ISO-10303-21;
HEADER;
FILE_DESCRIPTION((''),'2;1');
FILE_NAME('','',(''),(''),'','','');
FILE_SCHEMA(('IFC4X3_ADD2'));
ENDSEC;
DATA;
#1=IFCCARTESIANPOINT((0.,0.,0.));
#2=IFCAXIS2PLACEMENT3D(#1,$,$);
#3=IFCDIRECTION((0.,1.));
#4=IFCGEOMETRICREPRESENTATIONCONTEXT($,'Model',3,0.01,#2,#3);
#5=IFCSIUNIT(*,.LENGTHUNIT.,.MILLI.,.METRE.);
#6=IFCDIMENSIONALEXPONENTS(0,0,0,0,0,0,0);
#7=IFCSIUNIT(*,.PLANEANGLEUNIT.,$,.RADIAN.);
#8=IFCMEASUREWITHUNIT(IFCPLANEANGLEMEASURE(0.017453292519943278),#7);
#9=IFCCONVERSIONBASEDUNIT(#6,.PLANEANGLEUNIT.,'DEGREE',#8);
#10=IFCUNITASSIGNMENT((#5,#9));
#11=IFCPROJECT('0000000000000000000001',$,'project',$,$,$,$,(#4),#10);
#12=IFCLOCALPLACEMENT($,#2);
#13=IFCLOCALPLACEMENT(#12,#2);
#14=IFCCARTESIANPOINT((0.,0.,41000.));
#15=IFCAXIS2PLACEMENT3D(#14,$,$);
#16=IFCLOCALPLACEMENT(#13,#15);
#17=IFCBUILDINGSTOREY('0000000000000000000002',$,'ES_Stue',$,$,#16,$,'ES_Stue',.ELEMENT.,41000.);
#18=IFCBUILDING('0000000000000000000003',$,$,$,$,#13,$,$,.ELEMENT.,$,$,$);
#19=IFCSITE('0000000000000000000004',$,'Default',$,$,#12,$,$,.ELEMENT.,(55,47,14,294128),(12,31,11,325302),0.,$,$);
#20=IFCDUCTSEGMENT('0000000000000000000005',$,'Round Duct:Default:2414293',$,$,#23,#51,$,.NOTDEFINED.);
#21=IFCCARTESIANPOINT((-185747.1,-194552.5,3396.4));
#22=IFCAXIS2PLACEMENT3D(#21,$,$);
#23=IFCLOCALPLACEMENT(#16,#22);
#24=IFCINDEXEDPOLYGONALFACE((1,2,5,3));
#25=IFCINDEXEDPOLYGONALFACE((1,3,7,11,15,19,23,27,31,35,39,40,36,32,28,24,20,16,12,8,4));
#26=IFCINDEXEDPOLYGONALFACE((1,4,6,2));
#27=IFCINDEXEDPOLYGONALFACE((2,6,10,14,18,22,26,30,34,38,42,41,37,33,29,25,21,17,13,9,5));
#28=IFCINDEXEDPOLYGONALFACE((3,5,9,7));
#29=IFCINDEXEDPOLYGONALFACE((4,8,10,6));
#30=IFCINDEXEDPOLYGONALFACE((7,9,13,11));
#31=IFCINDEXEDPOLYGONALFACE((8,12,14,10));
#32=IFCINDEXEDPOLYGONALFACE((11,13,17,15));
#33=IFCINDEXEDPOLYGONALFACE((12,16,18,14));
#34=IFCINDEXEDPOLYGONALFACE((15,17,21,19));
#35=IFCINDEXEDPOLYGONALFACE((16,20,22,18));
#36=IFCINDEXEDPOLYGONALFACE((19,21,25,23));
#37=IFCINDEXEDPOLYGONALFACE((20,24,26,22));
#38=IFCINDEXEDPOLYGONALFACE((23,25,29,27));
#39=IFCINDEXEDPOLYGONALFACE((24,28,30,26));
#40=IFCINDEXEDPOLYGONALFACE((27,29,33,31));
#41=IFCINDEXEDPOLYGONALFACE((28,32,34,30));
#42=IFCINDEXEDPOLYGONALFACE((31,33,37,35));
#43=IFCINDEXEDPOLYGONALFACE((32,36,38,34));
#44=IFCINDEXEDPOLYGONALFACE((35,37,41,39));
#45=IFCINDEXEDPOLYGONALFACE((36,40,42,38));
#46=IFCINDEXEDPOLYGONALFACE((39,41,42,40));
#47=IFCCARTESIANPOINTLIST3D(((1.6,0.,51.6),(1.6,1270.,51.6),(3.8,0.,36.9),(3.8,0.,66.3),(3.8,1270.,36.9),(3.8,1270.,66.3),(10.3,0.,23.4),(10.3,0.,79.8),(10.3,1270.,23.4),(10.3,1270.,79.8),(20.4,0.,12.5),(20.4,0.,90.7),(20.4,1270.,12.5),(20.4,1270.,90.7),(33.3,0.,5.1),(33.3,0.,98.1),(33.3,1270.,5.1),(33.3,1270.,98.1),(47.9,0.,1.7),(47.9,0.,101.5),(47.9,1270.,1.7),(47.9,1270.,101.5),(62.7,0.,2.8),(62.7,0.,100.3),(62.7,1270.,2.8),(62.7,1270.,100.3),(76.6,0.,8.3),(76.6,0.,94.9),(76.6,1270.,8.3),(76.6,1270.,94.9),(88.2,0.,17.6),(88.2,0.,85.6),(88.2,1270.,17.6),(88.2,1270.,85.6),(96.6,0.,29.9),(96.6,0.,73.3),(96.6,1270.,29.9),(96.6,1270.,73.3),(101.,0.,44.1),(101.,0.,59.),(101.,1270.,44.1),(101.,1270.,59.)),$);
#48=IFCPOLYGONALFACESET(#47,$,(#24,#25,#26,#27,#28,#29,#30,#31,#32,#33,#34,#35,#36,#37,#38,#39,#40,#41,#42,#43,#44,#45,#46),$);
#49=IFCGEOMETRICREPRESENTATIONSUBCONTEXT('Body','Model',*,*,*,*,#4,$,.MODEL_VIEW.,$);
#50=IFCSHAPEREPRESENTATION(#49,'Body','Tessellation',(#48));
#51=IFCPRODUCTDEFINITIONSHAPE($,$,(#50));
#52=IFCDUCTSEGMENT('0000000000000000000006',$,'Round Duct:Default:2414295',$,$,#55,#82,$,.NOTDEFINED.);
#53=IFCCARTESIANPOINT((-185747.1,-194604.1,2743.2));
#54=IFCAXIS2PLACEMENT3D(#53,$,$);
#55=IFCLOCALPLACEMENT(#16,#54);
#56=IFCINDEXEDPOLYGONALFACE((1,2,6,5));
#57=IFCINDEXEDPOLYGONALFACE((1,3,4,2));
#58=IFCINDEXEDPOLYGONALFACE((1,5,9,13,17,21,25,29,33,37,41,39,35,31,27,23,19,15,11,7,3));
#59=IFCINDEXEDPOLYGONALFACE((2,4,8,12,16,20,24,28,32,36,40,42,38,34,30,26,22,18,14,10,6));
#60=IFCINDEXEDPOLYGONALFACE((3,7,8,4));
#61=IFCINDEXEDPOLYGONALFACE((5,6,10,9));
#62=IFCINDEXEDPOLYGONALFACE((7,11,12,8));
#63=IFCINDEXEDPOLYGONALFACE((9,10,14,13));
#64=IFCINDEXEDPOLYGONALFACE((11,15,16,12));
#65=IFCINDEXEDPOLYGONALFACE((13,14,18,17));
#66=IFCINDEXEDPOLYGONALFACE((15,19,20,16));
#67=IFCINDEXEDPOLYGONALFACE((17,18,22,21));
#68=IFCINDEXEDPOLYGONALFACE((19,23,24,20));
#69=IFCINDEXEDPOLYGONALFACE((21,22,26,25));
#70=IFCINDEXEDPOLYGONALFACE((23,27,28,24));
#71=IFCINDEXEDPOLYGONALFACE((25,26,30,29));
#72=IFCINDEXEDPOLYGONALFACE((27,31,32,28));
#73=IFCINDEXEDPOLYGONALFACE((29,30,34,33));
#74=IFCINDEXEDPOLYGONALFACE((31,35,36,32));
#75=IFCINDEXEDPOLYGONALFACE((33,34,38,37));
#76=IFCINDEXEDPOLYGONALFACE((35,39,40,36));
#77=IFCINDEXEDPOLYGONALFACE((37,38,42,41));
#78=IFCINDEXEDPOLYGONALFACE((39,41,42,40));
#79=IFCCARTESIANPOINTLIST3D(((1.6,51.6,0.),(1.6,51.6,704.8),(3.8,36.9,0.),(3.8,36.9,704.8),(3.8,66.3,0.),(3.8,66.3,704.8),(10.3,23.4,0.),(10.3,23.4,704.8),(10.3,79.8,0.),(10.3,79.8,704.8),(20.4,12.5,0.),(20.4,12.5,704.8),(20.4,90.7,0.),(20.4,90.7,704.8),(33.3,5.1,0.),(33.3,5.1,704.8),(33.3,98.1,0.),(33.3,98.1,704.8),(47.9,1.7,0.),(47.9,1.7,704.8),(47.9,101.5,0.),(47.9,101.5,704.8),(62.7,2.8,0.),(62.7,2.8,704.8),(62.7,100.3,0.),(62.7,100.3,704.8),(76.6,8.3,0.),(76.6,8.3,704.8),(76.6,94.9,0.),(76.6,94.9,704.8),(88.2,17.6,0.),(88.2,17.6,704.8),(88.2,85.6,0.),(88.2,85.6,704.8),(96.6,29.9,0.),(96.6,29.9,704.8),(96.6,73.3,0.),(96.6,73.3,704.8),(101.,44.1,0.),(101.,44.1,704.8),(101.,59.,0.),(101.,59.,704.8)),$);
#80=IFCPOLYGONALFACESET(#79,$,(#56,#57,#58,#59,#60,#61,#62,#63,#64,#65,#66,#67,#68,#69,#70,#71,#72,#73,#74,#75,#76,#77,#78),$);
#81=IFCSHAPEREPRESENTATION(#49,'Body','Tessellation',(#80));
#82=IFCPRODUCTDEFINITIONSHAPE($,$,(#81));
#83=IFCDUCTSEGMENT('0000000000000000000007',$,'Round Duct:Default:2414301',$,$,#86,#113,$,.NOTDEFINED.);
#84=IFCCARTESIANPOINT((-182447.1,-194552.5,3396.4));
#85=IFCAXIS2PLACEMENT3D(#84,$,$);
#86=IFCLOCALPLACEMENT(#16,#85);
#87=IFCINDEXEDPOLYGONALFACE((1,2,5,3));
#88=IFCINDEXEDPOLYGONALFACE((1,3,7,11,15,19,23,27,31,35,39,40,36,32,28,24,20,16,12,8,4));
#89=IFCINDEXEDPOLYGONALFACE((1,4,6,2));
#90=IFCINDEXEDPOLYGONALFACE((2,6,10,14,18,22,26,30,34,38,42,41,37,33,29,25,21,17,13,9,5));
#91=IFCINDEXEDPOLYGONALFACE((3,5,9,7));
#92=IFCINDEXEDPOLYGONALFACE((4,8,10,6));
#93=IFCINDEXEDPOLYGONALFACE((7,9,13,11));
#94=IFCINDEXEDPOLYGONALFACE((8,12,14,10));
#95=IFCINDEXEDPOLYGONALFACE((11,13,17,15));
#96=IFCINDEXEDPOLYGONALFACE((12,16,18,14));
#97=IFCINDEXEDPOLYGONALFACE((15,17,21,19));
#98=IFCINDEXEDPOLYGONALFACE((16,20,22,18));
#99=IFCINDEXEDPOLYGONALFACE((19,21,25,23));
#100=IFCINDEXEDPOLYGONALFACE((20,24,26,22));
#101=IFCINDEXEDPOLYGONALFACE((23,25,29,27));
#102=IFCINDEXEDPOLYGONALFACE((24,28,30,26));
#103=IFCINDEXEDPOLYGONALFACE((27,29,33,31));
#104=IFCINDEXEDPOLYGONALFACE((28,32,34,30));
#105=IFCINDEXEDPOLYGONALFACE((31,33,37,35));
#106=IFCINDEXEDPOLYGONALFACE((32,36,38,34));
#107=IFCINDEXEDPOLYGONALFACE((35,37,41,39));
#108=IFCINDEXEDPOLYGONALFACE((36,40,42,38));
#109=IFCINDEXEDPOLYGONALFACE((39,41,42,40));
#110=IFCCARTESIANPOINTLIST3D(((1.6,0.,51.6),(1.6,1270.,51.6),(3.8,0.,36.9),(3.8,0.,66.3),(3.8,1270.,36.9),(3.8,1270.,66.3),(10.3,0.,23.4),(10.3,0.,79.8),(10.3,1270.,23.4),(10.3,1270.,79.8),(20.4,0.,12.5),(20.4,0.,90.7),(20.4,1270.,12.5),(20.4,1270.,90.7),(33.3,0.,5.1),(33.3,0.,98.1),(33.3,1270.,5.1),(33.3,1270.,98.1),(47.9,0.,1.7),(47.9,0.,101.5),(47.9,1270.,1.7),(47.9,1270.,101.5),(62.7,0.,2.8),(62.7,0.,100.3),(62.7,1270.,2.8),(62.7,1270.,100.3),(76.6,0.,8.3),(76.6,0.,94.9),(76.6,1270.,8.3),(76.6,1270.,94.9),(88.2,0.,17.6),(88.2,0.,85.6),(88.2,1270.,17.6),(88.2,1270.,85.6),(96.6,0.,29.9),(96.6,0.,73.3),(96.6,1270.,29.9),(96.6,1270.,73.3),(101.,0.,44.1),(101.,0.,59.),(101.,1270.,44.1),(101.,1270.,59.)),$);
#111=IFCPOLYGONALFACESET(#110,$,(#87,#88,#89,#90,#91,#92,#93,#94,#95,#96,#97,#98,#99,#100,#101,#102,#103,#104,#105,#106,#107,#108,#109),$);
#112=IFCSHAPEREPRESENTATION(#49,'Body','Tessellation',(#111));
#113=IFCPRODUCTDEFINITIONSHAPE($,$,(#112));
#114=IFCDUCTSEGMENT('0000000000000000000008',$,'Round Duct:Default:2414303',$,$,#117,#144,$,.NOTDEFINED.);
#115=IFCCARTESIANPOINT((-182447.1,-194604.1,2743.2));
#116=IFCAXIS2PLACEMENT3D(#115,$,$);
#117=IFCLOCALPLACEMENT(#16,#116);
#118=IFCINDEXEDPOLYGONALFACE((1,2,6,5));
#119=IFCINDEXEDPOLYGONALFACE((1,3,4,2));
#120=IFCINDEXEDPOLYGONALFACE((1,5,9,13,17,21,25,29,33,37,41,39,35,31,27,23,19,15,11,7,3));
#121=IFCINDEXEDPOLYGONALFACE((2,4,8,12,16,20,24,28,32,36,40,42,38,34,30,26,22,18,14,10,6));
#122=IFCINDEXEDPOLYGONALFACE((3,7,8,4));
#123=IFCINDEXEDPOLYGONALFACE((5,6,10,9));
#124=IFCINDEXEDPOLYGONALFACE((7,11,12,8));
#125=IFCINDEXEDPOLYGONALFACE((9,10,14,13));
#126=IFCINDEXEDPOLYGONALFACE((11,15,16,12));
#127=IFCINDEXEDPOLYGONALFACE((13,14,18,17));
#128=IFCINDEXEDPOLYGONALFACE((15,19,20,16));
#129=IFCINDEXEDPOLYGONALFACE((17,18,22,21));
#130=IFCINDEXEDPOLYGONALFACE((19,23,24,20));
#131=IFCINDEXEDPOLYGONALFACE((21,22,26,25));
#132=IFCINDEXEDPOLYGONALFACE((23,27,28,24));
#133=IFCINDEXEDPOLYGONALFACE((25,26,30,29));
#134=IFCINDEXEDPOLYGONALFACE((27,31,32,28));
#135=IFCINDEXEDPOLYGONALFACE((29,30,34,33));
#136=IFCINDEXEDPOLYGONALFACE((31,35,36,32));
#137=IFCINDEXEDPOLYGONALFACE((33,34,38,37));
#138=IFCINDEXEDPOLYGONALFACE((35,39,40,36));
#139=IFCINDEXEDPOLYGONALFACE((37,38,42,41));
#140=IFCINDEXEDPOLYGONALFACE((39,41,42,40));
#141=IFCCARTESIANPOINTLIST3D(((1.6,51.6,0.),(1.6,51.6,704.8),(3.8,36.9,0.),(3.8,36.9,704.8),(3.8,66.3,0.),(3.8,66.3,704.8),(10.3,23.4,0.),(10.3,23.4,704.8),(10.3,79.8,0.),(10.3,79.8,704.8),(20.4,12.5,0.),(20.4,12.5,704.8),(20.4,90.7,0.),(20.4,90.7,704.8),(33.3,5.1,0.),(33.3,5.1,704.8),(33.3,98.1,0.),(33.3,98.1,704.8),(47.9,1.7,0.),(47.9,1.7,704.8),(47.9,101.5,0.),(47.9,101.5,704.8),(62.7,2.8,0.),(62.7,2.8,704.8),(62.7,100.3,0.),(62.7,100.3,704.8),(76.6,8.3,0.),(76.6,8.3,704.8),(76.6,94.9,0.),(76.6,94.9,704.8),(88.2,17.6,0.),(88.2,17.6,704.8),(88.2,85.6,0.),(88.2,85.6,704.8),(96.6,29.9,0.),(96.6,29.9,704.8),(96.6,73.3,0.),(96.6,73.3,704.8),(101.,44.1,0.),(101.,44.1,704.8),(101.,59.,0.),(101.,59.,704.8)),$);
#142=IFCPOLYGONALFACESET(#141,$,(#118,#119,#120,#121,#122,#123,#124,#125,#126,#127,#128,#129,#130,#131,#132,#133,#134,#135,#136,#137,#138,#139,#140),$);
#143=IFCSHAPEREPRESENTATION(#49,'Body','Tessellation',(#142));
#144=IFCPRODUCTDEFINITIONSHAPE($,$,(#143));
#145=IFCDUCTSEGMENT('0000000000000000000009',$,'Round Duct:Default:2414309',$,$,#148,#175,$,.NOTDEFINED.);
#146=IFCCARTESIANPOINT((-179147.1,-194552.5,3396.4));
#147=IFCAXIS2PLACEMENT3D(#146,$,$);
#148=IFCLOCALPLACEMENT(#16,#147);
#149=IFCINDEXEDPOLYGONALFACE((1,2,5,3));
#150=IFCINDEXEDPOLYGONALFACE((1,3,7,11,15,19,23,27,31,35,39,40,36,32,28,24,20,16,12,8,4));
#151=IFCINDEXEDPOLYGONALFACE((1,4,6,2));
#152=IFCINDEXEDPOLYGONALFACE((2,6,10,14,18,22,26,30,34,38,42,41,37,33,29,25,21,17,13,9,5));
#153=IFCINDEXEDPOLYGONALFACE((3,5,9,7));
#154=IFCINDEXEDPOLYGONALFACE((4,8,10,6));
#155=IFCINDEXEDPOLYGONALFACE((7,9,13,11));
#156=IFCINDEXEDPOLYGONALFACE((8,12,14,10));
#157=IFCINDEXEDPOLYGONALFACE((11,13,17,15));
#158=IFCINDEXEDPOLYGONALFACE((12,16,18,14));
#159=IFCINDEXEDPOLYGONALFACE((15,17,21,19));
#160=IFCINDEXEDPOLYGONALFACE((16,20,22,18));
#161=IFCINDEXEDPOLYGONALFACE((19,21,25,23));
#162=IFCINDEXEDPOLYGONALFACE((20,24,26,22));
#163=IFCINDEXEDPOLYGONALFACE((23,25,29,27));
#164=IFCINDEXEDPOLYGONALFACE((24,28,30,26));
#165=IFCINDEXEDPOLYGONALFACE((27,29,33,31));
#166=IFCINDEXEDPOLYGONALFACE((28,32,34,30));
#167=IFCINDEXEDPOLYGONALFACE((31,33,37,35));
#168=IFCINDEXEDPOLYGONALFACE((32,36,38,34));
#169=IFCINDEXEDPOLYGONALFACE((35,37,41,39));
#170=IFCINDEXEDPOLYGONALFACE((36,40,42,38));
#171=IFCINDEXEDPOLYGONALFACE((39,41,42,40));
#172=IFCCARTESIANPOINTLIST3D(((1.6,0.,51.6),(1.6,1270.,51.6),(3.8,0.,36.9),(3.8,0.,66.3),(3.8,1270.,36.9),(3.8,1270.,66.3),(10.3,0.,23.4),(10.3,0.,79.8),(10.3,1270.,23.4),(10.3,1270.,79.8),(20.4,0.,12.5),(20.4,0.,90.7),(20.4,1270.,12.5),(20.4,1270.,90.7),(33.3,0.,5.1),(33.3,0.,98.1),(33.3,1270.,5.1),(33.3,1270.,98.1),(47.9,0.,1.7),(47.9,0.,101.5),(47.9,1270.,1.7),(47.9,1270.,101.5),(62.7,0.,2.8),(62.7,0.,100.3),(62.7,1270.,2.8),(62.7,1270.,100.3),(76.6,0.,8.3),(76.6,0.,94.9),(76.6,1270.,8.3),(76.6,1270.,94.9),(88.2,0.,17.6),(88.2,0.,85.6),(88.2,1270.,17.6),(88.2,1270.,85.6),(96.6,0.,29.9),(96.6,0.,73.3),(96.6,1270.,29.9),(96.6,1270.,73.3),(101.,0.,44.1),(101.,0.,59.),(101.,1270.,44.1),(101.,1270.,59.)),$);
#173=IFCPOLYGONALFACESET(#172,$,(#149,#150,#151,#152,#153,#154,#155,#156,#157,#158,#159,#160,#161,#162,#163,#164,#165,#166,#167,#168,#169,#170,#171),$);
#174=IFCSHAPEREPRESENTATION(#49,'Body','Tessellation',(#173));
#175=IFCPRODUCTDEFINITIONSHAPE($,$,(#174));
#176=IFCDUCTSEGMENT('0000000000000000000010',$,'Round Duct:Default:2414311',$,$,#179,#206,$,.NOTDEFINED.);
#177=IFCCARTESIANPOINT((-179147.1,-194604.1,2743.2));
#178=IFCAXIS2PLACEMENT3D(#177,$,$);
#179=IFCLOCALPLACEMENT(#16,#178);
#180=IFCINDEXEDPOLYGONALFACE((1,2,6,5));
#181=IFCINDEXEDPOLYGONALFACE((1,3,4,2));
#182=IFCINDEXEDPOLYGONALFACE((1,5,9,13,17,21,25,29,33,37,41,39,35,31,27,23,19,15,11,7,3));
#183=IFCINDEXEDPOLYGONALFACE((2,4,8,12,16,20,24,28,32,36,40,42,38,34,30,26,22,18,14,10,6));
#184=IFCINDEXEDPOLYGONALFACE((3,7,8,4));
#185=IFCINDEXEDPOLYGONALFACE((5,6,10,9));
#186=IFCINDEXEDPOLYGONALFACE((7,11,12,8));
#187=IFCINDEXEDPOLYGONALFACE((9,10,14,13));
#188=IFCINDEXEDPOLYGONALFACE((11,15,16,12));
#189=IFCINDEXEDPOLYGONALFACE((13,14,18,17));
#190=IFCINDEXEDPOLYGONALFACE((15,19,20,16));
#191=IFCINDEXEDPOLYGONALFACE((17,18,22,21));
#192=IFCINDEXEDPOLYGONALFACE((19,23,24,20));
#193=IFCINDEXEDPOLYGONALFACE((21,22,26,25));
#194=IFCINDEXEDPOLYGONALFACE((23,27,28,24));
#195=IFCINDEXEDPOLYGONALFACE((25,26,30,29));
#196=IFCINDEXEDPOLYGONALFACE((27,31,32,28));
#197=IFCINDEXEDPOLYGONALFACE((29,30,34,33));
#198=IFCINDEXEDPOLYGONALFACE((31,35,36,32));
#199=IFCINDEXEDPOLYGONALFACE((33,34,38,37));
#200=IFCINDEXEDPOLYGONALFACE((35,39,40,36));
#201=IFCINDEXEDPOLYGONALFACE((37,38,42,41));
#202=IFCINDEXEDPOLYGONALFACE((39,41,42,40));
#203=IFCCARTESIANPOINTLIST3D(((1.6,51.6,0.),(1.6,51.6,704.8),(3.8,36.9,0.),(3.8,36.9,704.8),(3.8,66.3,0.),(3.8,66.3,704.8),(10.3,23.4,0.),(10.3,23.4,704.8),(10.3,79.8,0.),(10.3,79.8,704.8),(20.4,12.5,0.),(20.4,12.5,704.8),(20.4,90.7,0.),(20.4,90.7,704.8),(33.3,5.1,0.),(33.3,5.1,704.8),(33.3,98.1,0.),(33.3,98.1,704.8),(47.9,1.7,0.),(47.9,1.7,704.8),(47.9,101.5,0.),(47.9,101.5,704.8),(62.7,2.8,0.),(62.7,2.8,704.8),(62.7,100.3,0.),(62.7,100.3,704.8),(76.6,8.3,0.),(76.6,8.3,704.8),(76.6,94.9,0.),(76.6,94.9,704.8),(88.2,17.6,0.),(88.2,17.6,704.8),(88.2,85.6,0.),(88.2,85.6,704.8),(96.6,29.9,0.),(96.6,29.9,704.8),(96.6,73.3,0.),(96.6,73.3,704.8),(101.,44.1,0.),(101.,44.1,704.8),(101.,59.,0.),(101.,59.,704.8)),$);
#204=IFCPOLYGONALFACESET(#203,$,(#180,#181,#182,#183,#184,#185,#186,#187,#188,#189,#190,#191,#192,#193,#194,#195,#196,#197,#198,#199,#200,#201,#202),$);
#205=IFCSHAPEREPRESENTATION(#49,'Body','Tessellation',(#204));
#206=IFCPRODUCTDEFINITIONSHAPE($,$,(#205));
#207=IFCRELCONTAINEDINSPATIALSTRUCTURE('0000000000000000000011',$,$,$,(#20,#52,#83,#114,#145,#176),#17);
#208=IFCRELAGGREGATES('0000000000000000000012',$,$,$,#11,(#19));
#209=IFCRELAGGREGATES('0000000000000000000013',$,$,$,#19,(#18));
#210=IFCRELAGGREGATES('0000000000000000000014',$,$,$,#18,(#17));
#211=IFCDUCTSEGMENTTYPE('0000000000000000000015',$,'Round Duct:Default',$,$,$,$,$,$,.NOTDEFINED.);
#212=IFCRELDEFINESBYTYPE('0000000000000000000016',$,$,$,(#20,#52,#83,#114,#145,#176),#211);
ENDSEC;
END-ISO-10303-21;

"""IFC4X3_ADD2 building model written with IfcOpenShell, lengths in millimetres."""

from ifc_helpers import new_model, entity, si_unit, converted_unit, direction, frame, origin, origin_2d_with_axis, place, context, subcontext, project, spatial, circle, extrude, type_object, element, save


model = new_model("IFC4X3_ADD2")

# Units and contexts
model_context = context("Model", 3, precision=0.01, world=origin(), true_north=direction((0.0, 1.0)))
body_context = subcontext(model_context, "Body", "Model", "MODEL_VIEW")
ifc_project = project(units=[si_unit("LENGTHUNIT", "METRE", prefix="MILLI"), converted_unit("PLANEANGLEUNIT", "DEGREE", entity("IfcPlaneAngleMeasure", 0.017453292519943278), si_unit("PLANEANGLEUNIT", "RADIAN"), dimensions=[0, 0, 0, 0, 0, 0, 0])], contexts=[model_context])

# Site, building, storey
site_placement = place(None, origin())
site = spatial("IfcSite", under=ifc_project, at=site_placement, Name="Default", CompositionType="ELEMENT", RefLatitude=(55, 47, 14, 294128), RefLongitude=(12, 31, 11, 325302), RefElevation=0.0)
building_placement = place(site_placement, origin())
building = spatial("IfcBuilding", under=site, at=building_placement, CompositionType="ELEMENT")
storey_placement = place(building_placement, frame((0.0, 0.0, 41000.0)))
storey = spatial("IfcBuildingStorey", under=building, at=storey_placement, Name="ES_Stue", LongName="ES_Stue", CompositionType="ELEMENT", Elevation=41000.0)

# Duct segments
duct_segment_type = type_object("IfcDuctSegmentType", Name="Round Duct:Default", PredefinedType="NOTDEFINED")
duct_segment_1_placement = place(storey_placement, frame((-185747.1, -194552.5, 3396.4)))
element("IfcDuctSegment", 1, at=duct_segment_1_placement, inside=storey, type_object=duct_segment_type, Name="Round Duct:Default:2414293", PredefinedType="NOTDEFINED", context=body_context, shape_type="SweptSolid", body=[
    extrude(circle(Radius=50.0, at=origin_2d_with_axis()), frame((51.6, 0.0, 51.6), z_axis=(0.0, 1.0, 0.0), x_axis=(-1.0, 0.0, 0.0)), (0.0, 0.0, 1.0), 1270.0),
])
duct_segment_2_placement = place(storey_placement, frame((-185747.1, -194604.1, 2743.2)))
element("IfcDuctSegment", 2, at=duct_segment_2_placement, inside=storey, type_object=duct_segment_type, Name="Round Duct:Default:2414295", PredefinedType="NOTDEFINED", context=body_context, shape_type="SweptSolid", body=[
    extrude(circle(Radius=50.0, at=origin_2d_with_axis()), frame((51.6, 51.6, 0.0), z_axis=(0.0, 0.0, 1.0), x_axis=(-1.0, 0.0, 0.0)), (0.0, 0.0, 1.0), 704.8),
])
duct_segment_3_placement = place(storey_placement, frame((-182447.1, -194552.5, 3396.4)))
element("IfcDuctSegment", 3, at=duct_segment_3_placement, inside=storey, type_object=duct_segment_type, Name="Round Duct:Default:2414301", PredefinedType="NOTDEFINED", context=body_context, shape_type="SweptSolid", body=[
    extrude(circle(Radius=50.0, at=origin_2d_with_axis()), frame((51.6, 0.0, 51.6), z_axis=(0.0, 1.0, 0.0), x_axis=(-1.0, 0.0, 0.0)), (0.0, 0.0, 1.0), 1270.0),
])
duct_segment_4_placement = place(storey_placement, frame((-182447.1, -194604.1, 2743.2)))
element("IfcDuctSegment", 4, at=duct_segment_4_placement, inside=storey, type_object=duct_segment_type, Name="Round Duct:Default:2414303", PredefinedType="NOTDEFINED", context=body_context, shape_type="SweptSolid", body=[
    extrude(circle(Radius=50.0, at=origin_2d_with_axis()), frame((51.6, 51.6, 0.0), z_axis=(0.0, 0.0, 1.0), x_axis=(-1.0, 0.0, 0.0)), (0.0, 0.0, 1.0), 704.8),
])
duct_segment_5_placement = place(storey_placement, frame((-179147.1, -194552.5, 3396.4)))
element("IfcDuctSegment", 5, at=duct_segment_5_placement, inside=storey, type_object=duct_segment_type, Name="Round Duct:Default:2414309", PredefinedType="NOTDEFINED", context=body_context, shape_type="SweptSolid", body=[
    extrude(circle(Radius=50.0, at=origin_2d_with_axis()), frame((51.6, 0.0, 51.6), z_axis=(0.0, 1.0, 0.0), x_axis=(-1.0, 0.0, 0.0)), (0.0, 0.0, 1.0), 1270.0),
])
duct_segment_6_placement = place(storey_placement, frame((-179147.1, -194604.1, 2743.2)))
element("IfcDuctSegment", 6, at=duct_segment_6_placement, inside=storey, type_object=duct_segment_type, Name="Round Duct:Default:2414311", PredefinedType="NOTDEFINED", context=body_context, shape_type="SweptSolid", body=[
    extrude(circle(Radius=50.0, at=origin_2d_with_axis()), frame((51.6, 51.6, 0.0), z_axis=(0.0, 0.0, 1.0), x_axis=(-1.0, 0.0, 0.0)), (0.0, 0.0, 1.0), 704.8),
])

save(model, "model.ifc")
